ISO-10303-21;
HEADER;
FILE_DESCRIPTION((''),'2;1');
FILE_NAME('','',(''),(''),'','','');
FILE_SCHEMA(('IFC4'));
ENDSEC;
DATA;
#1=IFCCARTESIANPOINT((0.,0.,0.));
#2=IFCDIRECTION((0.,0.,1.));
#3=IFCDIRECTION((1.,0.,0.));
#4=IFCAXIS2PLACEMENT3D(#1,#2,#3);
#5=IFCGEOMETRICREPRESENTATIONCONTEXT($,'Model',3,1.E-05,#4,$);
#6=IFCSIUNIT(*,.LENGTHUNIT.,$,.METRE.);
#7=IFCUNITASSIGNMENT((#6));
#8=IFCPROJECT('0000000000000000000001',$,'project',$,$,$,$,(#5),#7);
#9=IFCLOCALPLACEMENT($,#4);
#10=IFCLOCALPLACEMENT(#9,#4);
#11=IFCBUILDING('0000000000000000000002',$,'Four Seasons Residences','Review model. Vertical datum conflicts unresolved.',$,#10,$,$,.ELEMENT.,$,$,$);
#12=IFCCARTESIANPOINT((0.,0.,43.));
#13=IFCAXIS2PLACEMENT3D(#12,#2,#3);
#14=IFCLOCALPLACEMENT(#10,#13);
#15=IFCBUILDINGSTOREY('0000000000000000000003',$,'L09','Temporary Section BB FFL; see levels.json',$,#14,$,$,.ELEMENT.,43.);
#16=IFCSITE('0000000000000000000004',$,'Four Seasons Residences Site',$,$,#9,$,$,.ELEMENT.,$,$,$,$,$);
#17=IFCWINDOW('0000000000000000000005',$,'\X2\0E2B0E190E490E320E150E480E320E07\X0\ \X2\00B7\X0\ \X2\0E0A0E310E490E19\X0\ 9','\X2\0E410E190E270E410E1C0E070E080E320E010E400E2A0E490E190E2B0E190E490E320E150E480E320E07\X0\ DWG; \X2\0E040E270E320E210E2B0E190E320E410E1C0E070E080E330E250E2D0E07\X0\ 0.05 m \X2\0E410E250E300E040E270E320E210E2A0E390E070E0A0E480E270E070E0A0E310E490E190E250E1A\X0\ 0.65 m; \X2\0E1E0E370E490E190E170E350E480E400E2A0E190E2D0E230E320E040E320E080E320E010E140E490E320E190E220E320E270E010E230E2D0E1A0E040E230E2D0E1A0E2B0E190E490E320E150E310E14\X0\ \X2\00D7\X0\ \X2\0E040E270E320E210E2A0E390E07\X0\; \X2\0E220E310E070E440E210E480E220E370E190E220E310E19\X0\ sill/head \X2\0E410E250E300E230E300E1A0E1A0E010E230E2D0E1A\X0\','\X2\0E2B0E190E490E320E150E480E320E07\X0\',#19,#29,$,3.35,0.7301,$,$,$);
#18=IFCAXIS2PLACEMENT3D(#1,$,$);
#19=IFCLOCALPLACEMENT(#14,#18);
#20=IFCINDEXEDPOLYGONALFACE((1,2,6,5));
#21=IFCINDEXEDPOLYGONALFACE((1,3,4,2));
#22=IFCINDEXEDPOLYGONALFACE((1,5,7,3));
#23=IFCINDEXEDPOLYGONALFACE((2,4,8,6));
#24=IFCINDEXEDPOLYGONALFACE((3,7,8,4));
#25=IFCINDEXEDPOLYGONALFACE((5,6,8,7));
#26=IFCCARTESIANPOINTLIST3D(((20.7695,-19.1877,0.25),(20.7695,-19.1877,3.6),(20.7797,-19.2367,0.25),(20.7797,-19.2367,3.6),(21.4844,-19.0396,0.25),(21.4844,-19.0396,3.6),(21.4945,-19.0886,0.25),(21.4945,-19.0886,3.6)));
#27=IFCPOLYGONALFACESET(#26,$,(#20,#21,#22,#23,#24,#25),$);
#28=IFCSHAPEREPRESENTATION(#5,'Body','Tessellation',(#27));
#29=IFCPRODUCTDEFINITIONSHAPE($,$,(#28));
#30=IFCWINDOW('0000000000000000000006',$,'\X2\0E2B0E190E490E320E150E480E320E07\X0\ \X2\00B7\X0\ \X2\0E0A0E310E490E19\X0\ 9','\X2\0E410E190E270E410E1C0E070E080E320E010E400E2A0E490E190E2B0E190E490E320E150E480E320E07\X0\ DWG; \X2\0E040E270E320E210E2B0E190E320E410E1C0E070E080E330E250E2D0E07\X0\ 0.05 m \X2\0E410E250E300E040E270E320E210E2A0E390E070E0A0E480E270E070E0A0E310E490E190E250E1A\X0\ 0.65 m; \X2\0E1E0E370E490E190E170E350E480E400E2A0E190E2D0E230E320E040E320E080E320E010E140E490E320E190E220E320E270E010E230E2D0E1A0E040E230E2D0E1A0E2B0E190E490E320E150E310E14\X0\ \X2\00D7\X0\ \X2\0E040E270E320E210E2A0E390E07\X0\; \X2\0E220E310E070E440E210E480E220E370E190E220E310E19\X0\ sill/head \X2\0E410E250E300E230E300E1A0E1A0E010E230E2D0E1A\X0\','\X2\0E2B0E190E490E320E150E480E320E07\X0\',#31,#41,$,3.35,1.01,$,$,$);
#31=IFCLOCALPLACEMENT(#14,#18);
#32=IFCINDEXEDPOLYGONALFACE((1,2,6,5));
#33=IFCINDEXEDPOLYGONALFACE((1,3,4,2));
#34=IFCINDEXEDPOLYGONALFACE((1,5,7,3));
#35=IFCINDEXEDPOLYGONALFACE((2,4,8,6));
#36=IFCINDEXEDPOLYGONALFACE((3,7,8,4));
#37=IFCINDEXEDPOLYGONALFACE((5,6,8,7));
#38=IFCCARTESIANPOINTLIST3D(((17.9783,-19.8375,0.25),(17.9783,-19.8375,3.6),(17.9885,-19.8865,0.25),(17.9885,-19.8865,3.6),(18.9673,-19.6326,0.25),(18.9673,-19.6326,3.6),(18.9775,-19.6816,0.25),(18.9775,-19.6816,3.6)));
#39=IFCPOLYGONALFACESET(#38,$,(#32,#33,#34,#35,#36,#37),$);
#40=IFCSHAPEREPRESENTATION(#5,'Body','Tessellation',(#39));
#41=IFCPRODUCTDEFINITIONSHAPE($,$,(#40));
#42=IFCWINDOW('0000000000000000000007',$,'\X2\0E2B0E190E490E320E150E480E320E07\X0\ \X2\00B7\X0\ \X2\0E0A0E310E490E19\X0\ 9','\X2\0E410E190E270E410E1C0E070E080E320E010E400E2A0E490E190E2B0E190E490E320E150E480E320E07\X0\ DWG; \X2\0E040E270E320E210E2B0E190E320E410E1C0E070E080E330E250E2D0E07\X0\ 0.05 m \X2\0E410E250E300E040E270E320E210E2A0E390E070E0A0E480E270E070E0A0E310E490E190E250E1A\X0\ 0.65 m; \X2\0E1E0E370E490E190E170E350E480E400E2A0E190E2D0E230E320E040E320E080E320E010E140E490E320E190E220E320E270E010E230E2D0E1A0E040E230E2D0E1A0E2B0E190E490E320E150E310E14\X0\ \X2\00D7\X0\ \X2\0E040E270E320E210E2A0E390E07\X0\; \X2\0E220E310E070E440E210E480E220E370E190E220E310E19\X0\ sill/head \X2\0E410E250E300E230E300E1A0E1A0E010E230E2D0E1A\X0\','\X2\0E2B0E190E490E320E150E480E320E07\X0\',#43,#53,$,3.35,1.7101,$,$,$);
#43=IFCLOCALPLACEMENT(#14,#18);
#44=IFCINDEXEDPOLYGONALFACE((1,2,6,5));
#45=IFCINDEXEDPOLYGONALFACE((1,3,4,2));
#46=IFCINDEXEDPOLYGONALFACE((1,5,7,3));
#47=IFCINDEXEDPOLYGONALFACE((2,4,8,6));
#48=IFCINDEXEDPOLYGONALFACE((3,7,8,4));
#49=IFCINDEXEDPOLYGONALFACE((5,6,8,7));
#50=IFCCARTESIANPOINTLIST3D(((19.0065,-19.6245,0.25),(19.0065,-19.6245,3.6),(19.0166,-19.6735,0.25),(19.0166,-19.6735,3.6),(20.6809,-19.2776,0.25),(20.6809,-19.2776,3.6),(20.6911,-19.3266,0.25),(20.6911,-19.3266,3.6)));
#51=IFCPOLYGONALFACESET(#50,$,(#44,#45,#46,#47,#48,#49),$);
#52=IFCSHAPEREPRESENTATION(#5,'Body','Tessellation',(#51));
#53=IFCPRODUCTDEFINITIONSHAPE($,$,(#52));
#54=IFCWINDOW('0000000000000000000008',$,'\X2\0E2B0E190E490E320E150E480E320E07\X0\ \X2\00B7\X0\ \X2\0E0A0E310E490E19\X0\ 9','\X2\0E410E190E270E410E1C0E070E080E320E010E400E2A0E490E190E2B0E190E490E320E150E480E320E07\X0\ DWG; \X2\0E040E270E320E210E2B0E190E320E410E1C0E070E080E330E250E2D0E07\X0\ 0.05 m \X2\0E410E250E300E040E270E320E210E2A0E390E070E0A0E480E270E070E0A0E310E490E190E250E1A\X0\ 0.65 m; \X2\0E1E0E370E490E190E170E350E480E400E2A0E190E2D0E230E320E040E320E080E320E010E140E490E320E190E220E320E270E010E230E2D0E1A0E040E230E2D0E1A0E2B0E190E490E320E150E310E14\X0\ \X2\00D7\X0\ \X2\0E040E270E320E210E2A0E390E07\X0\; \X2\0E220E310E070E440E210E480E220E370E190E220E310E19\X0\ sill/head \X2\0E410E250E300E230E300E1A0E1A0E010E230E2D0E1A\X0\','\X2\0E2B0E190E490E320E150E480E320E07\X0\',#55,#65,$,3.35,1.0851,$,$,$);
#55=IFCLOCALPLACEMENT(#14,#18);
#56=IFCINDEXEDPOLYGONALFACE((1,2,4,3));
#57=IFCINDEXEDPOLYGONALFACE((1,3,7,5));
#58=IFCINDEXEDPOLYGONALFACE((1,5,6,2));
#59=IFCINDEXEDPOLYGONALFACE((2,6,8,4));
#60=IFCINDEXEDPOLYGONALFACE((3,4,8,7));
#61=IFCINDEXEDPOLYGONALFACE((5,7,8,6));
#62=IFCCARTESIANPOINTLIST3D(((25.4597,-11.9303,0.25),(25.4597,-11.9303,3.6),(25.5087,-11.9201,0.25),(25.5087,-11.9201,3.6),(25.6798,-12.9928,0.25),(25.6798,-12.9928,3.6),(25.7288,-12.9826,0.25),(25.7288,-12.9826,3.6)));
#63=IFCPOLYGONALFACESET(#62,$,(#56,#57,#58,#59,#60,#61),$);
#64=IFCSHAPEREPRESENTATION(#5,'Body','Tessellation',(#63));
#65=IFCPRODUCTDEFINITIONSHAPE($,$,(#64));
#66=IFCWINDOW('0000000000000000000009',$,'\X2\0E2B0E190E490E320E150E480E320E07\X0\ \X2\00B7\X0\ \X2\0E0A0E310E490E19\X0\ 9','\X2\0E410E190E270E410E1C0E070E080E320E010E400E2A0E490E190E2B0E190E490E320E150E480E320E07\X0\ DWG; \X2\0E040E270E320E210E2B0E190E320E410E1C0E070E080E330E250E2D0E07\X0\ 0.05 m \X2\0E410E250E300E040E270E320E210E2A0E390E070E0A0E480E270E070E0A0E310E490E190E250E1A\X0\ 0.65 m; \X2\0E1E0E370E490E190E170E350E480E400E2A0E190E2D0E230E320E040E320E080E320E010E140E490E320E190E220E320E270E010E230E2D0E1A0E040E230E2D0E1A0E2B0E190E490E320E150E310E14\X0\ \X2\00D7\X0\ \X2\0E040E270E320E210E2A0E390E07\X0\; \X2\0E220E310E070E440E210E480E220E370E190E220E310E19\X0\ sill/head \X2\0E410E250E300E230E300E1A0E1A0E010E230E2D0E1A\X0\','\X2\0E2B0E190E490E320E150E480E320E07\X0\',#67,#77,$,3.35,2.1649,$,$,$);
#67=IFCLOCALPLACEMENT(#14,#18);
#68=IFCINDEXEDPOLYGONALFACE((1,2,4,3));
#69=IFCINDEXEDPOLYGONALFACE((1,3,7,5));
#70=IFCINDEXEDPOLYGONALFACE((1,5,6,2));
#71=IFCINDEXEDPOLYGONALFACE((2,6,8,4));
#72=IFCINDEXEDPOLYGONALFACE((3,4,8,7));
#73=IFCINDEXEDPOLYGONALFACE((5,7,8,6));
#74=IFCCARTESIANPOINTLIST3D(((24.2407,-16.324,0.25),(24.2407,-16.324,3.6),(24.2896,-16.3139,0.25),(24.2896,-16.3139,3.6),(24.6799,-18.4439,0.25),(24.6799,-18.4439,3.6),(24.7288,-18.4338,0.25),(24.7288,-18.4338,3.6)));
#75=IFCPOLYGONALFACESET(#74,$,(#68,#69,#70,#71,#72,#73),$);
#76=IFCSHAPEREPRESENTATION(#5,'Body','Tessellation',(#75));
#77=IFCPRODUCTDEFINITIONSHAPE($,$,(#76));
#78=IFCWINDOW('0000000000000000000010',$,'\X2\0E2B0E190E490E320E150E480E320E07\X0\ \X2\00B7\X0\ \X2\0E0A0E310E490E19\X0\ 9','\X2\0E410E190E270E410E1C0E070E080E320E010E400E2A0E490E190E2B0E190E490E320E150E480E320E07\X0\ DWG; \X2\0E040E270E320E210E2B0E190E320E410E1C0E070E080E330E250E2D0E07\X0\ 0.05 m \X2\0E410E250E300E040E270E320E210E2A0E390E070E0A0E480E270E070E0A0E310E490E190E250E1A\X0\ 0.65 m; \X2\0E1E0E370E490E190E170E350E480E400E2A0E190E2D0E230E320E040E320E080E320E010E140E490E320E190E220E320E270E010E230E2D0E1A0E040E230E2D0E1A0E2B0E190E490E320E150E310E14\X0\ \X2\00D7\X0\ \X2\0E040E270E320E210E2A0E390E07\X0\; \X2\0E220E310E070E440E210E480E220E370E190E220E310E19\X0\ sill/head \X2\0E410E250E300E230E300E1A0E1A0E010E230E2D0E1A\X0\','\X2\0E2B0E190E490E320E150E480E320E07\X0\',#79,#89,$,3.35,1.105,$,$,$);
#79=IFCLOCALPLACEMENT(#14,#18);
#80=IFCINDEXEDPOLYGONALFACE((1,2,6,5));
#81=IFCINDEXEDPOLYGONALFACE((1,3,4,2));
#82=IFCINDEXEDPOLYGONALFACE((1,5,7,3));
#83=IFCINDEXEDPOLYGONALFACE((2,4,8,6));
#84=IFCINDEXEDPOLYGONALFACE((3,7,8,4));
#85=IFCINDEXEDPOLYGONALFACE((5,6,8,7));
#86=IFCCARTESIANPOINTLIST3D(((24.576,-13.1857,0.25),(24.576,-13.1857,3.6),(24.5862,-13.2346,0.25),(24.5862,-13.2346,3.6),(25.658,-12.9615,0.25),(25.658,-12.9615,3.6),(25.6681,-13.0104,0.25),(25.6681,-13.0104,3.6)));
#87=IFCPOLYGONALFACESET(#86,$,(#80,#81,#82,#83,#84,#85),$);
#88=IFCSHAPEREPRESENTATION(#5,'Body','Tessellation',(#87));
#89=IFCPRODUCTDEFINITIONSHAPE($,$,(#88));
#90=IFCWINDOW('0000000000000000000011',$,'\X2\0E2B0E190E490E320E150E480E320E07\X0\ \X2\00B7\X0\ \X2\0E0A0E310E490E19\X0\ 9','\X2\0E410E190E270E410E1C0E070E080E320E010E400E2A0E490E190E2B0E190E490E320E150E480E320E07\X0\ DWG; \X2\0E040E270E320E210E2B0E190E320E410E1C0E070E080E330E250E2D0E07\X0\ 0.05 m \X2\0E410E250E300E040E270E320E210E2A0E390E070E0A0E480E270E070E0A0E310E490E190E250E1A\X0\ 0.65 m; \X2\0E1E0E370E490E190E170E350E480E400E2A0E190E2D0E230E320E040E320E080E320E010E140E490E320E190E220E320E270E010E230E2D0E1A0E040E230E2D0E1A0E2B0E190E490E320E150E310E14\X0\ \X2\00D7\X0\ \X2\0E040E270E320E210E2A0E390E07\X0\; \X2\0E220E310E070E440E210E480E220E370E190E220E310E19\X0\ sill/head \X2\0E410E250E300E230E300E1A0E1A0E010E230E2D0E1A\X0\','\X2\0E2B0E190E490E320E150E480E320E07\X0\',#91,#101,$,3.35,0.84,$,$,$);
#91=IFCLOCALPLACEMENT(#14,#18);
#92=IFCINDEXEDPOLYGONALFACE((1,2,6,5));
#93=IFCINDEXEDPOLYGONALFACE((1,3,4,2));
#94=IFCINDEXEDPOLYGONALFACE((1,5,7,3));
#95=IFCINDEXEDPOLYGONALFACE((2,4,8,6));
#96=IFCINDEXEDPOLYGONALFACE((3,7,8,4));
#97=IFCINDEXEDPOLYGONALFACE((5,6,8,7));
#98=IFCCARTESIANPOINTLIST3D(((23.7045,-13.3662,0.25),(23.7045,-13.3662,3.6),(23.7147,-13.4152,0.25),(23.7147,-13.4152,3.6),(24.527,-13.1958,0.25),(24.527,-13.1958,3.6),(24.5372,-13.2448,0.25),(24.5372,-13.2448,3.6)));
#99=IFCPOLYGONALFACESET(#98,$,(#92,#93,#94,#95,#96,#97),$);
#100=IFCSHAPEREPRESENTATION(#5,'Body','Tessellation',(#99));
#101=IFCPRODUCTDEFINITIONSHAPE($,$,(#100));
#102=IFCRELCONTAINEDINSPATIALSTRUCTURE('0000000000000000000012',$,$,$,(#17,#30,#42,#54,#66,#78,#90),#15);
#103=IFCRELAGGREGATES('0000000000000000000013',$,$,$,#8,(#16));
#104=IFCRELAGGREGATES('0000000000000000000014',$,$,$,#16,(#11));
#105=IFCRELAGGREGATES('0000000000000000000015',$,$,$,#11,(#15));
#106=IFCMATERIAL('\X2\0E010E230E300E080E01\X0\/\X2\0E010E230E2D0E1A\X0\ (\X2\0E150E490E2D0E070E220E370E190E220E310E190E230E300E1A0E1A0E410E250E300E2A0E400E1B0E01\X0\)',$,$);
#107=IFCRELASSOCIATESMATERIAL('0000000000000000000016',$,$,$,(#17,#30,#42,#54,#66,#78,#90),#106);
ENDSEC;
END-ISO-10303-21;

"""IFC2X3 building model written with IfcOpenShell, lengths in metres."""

from ifc_helpers import new_model, si_unit, frame, origin_with_axes, place, context, project, spatial, polyline, outline, extrude, material, element, save


model = new_model("IFC2X3")

# Units and contexts
model_context = context("Model", 3, precision=1e-05, world=origin_with_axes())
ifc_project = project(units=[si_unit("LENGTHUNIT", "METRE")], contexts=[model_context])

# Site, building, storey
site_placement = place(None, origin_with_axes())
site = spatial("IfcSite", under=ifc_project, at=site_placement, Name="Four Seasons Residences Site", CompositionType="ELEMENT")
building_placement = place(site_placement, origin_with_axes())
building = spatial("IfcBuilding", under=site, at=building_placement, Name="Four Seasons Residences", Description="Review model. Vertical datum conflicts unresolved.", CompositionType="ELEMENT")
storey_placement = place(building_placement, frame((0.0, 0.0, 43.0), z_axis=(0.0, 0.0, 1.0), x_axis=(1.0, 0.0, 0.0)))
storey = spatial("IfcBuildingStorey", under=building, at=storey_placement, Name="L09", Description="Temporary Section BB FFL; see levels.json", CompositionType="ELEMENT", Elevation=43.0)

# Windows
ifc_material_1 = material(Name="กระจก/กรอบ (ต้องยืนยันระบบและสเปก)")
window_1_placement = place(storey_placement, origin_with_axes())
element("IfcWindow", 1, at=window_1_placement, inside=storey, material=ifc_material_1, Name="หน้าต่าง · ชั้น 9", Description="แนวแผงจากเส้นหน้าต่าง DWG; ความหนาแผงจำลอง 0.05 m และความสูงช่วงชั้นลบ 0.65 m; พื้นที่เสนอราคาจากด้านยาวกรอบครอบหน้าตัด × ความสูง; ยังไม่ยืนยัน sill/head และระบบกรอบ", ObjectType="หน้าต่าง", OverallHeight=3.35, OverallWidth=0.7301, context=model_context, shape_type="SweptSolid", body=[
    extrude(outline(polyline([(21.4844, -19.0396), (21.4945, -19.0886), (20.7797, -19.2367), (20.7695, -19.1877), (21.4844, -19.0396)])), frame((0.0, 0.0, 0.25), z_axis=(0.0, 0.0, 1.0), x_axis=(1.0, 0.0, 0.0)), (0.0, 0.0, 1.0), 3.35),
])
window_2_placement = place(storey_placement, origin_with_axes())
element("IfcWindow", 2, at=window_2_placement, inside=storey, material=ifc_material_1, Name="หน้าต่าง · ชั้น 9", Description="แนวแผงจากเส้นหน้าต่าง DWG; ความหนาแผงจำลอง 0.05 m และความสูงช่วงชั้นลบ 0.65 m; พื้นที่เสนอราคาจากด้านยาวกรอบครอบหน้าตัด × ความสูง; ยังไม่ยืนยัน sill/head และระบบกรอบ", ObjectType="หน้าต่าง", OverallHeight=3.35, OverallWidth=1.01, context=model_context, shape_type="SweptSolid", body=[
    extrude(outline(polyline([(18.9673, -19.6326), (18.9775, -19.6816), (17.9885, -19.8865), (17.9783, -19.8375), (18.9673, -19.6326)])), frame((0.0, 0.0, 0.25), z_axis=(0.0, 0.0, 1.0), x_axis=(1.0, 0.0, 0.0)), (0.0, 0.0, 1.0), 3.35),
])
window_3_placement = place(storey_placement, origin_with_axes())
element("IfcWindow", 3, at=window_3_placement, inside=storey, material=ifc_material_1, Name="หน้าต่าง · ชั้น 9", Description="แนวแผงจากเส้นหน้าต่าง DWG; ความหนาแผงจำลอง 0.05 m และความสูงช่วงชั้นลบ 0.65 m; พื้นที่เสนอราคาจากด้านยาวกรอบครอบหน้าตัด × ความสูง; ยังไม่ยืนยัน sill/head และระบบกรอบ", ObjectType="หน้าต่าง", OverallHeight=3.35, OverallWidth=1.7101, context=model_context, shape_type="SweptSolid", body=[
    extrude(outline(polyline([(20.6809, -19.2776), (20.6911, -19.3266), (19.0166, -19.6735), (19.0065, -19.6245), (20.6809, -19.2776)])), frame((0.0, 0.0, 0.25), z_axis=(0.0, 0.0, 1.0), x_axis=(1.0, 0.0, 0.0)), (0.0, 0.0, 1.0), 3.35),
])
window_4_placement = place(storey_placement, origin_with_axes())
element("IfcWindow", 4, at=window_4_placement, inside=storey, material=ifc_material_1, Name="หน้าต่าง · ชั้น 9", Description="แนวแผงจากเส้นหน้าต่าง DWG; ความหนาแผงจำลอง 0.05 m และความสูงช่วงชั้นลบ 0.65 m; พื้นที่เสนอราคาจากด้านยาวกรอบครอบหน้าตัด × ความสูง; ยังไม่ยืนยัน sill/head และระบบกรอบ", ObjectType="หน้าต่าง", OverallHeight=3.35, OverallWidth=1.0851, context=model_context, shape_type="SweptSolid", body=[
    extrude(outline(polyline([(25.7288, -12.9826), (25.6798, -12.9928), (25.4597, -11.9303), (25.5087, -11.9201), (25.7288, -12.9826)])), frame((0.0, 0.0, 0.25), z_axis=(0.0, 0.0, 1.0), x_axis=(1.0, 0.0, 0.0)), (0.0, 0.0, 1.0), 3.35),
])
window_5_placement = place(storey_placement, origin_with_axes())
element("IfcWindow", 5, at=window_5_placement, inside=storey, material=ifc_material_1, Name="หน้าต่าง · ชั้น 9", Description="แนวแผงจากเส้นหน้าต่าง DWG; ความหนาแผงจำลอง 0.05 m และความสูงช่วงชั้นลบ 0.65 m; พื้นที่เสนอราคาจากด้านยาวกรอบครอบหน้าตัด × ความสูง; ยังไม่ยืนยัน sill/head และระบบกรอบ", ObjectType="หน้าต่าง", OverallHeight=3.35, OverallWidth=2.1649, context=model_context, shape_type="SweptSolid", body=[
    extrude(outline(polyline([(24.7288, -18.4338), (24.6799, -18.4439), (24.2407, -16.324), (24.2896, -16.3139), (24.7288, -18.4338)])), frame((0.0, 0.0, 0.25), z_axis=(0.0, 0.0, 1.0), x_axis=(1.0, 0.0, 0.0)), (0.0, 0.0, 1.0), 3.35),
])
window_6_placement = place(storey_placement, origin_with_axes())
element("IfcWindow", 6, at=window_6_placement, inside=storey, material=ifc_material_1, Name="หน้าต่าง · ชั้น 9", Description="แนวแผงจากเส้นหน้าต่าง DWG; ความหนาแผงจำลอง 0.05 m และความสูงช่วงชั้นลบ 0.65 m; พื้นที่เสนอราคาจากด้านยาวกรอบครอบหน้าตัด × ความสูง; ยังไม่ยืนยัน sill/head และระบบกรอบ", ObjectType="หน้าต่าง", OverallHeight=3.35, OverallWidth=1.105, context=model_context, shape_type="SweptSolid", body=[
    extrude(outline(polyline([(24.5862, -13.2346), (24.576, -13.1857), (25.658, -12.9615), (25.6681, -13.0104), (24.5862, -13.2346)])), frame((0.0, 0.0, 0.25), z_axis=(0.0, 0.0, 1.0), x_axis=(1.0, 0.0, 0.0)), (0.0, 0.0, 1.0), 3.35),
])
window_7_placement = place(storey_placement, origin_with_axes())
element("IfcWindow", 7, at=window_7_placement, inside=storey, material=ifc_material_1, Name="หน้าต่าง · ชั้น 9", Description="แนวแผงจากเส้นหน้าต่าง DWG; ความหนาแผงจำลอง 0.05 m และความสูงช่วงชั้นลบ 0.65 m; พื้นที่เสนอราคาจากด้านยาวกรอบครอบหน้าตัด × ความสูง; ยังไม่ยืนยัน sill/head และระบบกรอบ", ObjectType="หน้าต่าง", OverallHeight=3.35, OverallWidth=0.84, context=model_context, shape_type="SweptSolid", body=[
    extrude(outline(polyline([(23.7147, -13.4152), (23.7045, -13.3662), (24.527, -13.1958), (24.5372, -13.2448), (23.7147, -13.4152)])), frame((0.0, 0.0, 0.25), z_axis=(0.0, 0.0, 1.0), x_axis=(1.0, 0.0, 0.0)), (0.0, 0.0, 1.0), 3.35),
])

save(model, "model.ifc")
